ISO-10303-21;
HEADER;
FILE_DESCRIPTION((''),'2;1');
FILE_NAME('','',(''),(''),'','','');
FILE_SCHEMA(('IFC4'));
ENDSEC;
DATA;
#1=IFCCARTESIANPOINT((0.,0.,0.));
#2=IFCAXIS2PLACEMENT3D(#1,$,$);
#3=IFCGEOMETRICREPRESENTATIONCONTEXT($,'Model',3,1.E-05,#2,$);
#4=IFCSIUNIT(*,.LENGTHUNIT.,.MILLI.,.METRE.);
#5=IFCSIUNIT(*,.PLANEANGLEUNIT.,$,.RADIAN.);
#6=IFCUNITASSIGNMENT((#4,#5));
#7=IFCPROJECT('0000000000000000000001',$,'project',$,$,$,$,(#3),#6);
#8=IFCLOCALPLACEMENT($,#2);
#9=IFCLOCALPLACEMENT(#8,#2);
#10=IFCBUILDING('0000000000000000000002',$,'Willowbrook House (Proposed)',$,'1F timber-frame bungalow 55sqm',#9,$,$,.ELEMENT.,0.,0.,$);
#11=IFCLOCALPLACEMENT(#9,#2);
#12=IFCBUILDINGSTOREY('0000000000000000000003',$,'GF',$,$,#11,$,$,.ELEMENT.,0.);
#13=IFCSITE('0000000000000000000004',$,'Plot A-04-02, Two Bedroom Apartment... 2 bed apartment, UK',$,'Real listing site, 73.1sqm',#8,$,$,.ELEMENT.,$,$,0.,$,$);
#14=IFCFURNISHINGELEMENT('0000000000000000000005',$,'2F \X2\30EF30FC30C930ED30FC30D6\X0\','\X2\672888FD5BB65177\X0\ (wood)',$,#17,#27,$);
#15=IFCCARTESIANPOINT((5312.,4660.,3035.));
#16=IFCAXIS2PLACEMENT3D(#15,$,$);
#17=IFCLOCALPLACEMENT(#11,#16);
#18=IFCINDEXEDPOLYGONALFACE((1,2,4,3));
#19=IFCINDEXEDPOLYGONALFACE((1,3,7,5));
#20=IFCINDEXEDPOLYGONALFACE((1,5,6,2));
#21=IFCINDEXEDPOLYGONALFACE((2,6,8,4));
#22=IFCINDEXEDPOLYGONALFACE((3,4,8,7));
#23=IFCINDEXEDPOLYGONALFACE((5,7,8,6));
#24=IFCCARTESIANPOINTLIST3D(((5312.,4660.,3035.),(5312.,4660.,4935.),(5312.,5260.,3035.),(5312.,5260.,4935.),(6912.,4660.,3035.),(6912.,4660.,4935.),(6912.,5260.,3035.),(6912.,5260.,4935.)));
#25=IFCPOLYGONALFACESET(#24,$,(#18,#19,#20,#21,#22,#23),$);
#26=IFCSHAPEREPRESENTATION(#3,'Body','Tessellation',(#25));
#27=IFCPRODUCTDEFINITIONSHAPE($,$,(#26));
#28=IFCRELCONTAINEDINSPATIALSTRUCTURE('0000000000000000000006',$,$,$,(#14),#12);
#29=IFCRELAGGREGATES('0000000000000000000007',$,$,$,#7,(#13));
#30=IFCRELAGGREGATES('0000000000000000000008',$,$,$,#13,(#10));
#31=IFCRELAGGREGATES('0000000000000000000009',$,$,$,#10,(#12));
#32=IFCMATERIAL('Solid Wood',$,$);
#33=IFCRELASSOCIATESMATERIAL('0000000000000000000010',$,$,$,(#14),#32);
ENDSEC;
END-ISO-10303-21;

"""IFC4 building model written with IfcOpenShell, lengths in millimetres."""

from ifc_helpers import new_model, si_unit, frame, frame_2d, origin, place, context, project, spatial, rectangle, extrude, material, element, save


model = new_model("IFC4")

# Units and contexts
model_context = context("Model", 3, precision=1e-05, world=origin())
ifc_project = project(units=[si_unit("LENGTHUNIT", "METRE", prefix="MILLI"), si_unit("PLANEANGLEUNIT", "RADIAN")], contexts=[model_context])

# Site, building, storey
site_placement = place(None, origin())
site = spatial("IfcSite", under=ifc_project, at=site_placement, Name="Plot A-04-02, Two Bedroom Apartment... 2 bed apartment, UK", ObjectType="Real listing site, 73.1sqm", CompositionType="ELEMENT", RefElevation=0.0)
building_placement = place(site_placement, origin())
building = spatial("IfcBuilding", under=site, at=building_placement, Name="Willowbrook House (Proposed)", ObjectType="1F timber-frame bungalow 55sqm", CompositionType="ELEMENT", ElevationOfRefHeight=0.0, ElevationOfTerrain=0.0)
storey_placement = place(building_placement, origin())
storey = spatial("IfcBuildingStorey", under=building, at=storey_placement, Name="GF", CompositionType="ELEMENT", Elevation=0.0)

# Shared definitions
ifc_material_1 = material(Name="Solid Wood")

# Furnishing element
furnishing_1_placement = place(storey_placement, frame((5312.0, 4660.0, 3035.0)))
element("IfcFurnishingElement", 1, at=furnishing_1_placement, inside=storey, material=ifc_material_1, Name="2F ワードローブ", Description="木製家具 (wood)", context=model_context, shape_type="SweptSolid", body=[
    extrude(rectangle(XDim=1600.0, YDim=600.0, at=frame_2d((800.0, 300.0))), frame((5312.0, 4660.0, 3035.0)), (0.0, 0.0, 1.0), 1900.0),
])

save(model, "model.ifc")
